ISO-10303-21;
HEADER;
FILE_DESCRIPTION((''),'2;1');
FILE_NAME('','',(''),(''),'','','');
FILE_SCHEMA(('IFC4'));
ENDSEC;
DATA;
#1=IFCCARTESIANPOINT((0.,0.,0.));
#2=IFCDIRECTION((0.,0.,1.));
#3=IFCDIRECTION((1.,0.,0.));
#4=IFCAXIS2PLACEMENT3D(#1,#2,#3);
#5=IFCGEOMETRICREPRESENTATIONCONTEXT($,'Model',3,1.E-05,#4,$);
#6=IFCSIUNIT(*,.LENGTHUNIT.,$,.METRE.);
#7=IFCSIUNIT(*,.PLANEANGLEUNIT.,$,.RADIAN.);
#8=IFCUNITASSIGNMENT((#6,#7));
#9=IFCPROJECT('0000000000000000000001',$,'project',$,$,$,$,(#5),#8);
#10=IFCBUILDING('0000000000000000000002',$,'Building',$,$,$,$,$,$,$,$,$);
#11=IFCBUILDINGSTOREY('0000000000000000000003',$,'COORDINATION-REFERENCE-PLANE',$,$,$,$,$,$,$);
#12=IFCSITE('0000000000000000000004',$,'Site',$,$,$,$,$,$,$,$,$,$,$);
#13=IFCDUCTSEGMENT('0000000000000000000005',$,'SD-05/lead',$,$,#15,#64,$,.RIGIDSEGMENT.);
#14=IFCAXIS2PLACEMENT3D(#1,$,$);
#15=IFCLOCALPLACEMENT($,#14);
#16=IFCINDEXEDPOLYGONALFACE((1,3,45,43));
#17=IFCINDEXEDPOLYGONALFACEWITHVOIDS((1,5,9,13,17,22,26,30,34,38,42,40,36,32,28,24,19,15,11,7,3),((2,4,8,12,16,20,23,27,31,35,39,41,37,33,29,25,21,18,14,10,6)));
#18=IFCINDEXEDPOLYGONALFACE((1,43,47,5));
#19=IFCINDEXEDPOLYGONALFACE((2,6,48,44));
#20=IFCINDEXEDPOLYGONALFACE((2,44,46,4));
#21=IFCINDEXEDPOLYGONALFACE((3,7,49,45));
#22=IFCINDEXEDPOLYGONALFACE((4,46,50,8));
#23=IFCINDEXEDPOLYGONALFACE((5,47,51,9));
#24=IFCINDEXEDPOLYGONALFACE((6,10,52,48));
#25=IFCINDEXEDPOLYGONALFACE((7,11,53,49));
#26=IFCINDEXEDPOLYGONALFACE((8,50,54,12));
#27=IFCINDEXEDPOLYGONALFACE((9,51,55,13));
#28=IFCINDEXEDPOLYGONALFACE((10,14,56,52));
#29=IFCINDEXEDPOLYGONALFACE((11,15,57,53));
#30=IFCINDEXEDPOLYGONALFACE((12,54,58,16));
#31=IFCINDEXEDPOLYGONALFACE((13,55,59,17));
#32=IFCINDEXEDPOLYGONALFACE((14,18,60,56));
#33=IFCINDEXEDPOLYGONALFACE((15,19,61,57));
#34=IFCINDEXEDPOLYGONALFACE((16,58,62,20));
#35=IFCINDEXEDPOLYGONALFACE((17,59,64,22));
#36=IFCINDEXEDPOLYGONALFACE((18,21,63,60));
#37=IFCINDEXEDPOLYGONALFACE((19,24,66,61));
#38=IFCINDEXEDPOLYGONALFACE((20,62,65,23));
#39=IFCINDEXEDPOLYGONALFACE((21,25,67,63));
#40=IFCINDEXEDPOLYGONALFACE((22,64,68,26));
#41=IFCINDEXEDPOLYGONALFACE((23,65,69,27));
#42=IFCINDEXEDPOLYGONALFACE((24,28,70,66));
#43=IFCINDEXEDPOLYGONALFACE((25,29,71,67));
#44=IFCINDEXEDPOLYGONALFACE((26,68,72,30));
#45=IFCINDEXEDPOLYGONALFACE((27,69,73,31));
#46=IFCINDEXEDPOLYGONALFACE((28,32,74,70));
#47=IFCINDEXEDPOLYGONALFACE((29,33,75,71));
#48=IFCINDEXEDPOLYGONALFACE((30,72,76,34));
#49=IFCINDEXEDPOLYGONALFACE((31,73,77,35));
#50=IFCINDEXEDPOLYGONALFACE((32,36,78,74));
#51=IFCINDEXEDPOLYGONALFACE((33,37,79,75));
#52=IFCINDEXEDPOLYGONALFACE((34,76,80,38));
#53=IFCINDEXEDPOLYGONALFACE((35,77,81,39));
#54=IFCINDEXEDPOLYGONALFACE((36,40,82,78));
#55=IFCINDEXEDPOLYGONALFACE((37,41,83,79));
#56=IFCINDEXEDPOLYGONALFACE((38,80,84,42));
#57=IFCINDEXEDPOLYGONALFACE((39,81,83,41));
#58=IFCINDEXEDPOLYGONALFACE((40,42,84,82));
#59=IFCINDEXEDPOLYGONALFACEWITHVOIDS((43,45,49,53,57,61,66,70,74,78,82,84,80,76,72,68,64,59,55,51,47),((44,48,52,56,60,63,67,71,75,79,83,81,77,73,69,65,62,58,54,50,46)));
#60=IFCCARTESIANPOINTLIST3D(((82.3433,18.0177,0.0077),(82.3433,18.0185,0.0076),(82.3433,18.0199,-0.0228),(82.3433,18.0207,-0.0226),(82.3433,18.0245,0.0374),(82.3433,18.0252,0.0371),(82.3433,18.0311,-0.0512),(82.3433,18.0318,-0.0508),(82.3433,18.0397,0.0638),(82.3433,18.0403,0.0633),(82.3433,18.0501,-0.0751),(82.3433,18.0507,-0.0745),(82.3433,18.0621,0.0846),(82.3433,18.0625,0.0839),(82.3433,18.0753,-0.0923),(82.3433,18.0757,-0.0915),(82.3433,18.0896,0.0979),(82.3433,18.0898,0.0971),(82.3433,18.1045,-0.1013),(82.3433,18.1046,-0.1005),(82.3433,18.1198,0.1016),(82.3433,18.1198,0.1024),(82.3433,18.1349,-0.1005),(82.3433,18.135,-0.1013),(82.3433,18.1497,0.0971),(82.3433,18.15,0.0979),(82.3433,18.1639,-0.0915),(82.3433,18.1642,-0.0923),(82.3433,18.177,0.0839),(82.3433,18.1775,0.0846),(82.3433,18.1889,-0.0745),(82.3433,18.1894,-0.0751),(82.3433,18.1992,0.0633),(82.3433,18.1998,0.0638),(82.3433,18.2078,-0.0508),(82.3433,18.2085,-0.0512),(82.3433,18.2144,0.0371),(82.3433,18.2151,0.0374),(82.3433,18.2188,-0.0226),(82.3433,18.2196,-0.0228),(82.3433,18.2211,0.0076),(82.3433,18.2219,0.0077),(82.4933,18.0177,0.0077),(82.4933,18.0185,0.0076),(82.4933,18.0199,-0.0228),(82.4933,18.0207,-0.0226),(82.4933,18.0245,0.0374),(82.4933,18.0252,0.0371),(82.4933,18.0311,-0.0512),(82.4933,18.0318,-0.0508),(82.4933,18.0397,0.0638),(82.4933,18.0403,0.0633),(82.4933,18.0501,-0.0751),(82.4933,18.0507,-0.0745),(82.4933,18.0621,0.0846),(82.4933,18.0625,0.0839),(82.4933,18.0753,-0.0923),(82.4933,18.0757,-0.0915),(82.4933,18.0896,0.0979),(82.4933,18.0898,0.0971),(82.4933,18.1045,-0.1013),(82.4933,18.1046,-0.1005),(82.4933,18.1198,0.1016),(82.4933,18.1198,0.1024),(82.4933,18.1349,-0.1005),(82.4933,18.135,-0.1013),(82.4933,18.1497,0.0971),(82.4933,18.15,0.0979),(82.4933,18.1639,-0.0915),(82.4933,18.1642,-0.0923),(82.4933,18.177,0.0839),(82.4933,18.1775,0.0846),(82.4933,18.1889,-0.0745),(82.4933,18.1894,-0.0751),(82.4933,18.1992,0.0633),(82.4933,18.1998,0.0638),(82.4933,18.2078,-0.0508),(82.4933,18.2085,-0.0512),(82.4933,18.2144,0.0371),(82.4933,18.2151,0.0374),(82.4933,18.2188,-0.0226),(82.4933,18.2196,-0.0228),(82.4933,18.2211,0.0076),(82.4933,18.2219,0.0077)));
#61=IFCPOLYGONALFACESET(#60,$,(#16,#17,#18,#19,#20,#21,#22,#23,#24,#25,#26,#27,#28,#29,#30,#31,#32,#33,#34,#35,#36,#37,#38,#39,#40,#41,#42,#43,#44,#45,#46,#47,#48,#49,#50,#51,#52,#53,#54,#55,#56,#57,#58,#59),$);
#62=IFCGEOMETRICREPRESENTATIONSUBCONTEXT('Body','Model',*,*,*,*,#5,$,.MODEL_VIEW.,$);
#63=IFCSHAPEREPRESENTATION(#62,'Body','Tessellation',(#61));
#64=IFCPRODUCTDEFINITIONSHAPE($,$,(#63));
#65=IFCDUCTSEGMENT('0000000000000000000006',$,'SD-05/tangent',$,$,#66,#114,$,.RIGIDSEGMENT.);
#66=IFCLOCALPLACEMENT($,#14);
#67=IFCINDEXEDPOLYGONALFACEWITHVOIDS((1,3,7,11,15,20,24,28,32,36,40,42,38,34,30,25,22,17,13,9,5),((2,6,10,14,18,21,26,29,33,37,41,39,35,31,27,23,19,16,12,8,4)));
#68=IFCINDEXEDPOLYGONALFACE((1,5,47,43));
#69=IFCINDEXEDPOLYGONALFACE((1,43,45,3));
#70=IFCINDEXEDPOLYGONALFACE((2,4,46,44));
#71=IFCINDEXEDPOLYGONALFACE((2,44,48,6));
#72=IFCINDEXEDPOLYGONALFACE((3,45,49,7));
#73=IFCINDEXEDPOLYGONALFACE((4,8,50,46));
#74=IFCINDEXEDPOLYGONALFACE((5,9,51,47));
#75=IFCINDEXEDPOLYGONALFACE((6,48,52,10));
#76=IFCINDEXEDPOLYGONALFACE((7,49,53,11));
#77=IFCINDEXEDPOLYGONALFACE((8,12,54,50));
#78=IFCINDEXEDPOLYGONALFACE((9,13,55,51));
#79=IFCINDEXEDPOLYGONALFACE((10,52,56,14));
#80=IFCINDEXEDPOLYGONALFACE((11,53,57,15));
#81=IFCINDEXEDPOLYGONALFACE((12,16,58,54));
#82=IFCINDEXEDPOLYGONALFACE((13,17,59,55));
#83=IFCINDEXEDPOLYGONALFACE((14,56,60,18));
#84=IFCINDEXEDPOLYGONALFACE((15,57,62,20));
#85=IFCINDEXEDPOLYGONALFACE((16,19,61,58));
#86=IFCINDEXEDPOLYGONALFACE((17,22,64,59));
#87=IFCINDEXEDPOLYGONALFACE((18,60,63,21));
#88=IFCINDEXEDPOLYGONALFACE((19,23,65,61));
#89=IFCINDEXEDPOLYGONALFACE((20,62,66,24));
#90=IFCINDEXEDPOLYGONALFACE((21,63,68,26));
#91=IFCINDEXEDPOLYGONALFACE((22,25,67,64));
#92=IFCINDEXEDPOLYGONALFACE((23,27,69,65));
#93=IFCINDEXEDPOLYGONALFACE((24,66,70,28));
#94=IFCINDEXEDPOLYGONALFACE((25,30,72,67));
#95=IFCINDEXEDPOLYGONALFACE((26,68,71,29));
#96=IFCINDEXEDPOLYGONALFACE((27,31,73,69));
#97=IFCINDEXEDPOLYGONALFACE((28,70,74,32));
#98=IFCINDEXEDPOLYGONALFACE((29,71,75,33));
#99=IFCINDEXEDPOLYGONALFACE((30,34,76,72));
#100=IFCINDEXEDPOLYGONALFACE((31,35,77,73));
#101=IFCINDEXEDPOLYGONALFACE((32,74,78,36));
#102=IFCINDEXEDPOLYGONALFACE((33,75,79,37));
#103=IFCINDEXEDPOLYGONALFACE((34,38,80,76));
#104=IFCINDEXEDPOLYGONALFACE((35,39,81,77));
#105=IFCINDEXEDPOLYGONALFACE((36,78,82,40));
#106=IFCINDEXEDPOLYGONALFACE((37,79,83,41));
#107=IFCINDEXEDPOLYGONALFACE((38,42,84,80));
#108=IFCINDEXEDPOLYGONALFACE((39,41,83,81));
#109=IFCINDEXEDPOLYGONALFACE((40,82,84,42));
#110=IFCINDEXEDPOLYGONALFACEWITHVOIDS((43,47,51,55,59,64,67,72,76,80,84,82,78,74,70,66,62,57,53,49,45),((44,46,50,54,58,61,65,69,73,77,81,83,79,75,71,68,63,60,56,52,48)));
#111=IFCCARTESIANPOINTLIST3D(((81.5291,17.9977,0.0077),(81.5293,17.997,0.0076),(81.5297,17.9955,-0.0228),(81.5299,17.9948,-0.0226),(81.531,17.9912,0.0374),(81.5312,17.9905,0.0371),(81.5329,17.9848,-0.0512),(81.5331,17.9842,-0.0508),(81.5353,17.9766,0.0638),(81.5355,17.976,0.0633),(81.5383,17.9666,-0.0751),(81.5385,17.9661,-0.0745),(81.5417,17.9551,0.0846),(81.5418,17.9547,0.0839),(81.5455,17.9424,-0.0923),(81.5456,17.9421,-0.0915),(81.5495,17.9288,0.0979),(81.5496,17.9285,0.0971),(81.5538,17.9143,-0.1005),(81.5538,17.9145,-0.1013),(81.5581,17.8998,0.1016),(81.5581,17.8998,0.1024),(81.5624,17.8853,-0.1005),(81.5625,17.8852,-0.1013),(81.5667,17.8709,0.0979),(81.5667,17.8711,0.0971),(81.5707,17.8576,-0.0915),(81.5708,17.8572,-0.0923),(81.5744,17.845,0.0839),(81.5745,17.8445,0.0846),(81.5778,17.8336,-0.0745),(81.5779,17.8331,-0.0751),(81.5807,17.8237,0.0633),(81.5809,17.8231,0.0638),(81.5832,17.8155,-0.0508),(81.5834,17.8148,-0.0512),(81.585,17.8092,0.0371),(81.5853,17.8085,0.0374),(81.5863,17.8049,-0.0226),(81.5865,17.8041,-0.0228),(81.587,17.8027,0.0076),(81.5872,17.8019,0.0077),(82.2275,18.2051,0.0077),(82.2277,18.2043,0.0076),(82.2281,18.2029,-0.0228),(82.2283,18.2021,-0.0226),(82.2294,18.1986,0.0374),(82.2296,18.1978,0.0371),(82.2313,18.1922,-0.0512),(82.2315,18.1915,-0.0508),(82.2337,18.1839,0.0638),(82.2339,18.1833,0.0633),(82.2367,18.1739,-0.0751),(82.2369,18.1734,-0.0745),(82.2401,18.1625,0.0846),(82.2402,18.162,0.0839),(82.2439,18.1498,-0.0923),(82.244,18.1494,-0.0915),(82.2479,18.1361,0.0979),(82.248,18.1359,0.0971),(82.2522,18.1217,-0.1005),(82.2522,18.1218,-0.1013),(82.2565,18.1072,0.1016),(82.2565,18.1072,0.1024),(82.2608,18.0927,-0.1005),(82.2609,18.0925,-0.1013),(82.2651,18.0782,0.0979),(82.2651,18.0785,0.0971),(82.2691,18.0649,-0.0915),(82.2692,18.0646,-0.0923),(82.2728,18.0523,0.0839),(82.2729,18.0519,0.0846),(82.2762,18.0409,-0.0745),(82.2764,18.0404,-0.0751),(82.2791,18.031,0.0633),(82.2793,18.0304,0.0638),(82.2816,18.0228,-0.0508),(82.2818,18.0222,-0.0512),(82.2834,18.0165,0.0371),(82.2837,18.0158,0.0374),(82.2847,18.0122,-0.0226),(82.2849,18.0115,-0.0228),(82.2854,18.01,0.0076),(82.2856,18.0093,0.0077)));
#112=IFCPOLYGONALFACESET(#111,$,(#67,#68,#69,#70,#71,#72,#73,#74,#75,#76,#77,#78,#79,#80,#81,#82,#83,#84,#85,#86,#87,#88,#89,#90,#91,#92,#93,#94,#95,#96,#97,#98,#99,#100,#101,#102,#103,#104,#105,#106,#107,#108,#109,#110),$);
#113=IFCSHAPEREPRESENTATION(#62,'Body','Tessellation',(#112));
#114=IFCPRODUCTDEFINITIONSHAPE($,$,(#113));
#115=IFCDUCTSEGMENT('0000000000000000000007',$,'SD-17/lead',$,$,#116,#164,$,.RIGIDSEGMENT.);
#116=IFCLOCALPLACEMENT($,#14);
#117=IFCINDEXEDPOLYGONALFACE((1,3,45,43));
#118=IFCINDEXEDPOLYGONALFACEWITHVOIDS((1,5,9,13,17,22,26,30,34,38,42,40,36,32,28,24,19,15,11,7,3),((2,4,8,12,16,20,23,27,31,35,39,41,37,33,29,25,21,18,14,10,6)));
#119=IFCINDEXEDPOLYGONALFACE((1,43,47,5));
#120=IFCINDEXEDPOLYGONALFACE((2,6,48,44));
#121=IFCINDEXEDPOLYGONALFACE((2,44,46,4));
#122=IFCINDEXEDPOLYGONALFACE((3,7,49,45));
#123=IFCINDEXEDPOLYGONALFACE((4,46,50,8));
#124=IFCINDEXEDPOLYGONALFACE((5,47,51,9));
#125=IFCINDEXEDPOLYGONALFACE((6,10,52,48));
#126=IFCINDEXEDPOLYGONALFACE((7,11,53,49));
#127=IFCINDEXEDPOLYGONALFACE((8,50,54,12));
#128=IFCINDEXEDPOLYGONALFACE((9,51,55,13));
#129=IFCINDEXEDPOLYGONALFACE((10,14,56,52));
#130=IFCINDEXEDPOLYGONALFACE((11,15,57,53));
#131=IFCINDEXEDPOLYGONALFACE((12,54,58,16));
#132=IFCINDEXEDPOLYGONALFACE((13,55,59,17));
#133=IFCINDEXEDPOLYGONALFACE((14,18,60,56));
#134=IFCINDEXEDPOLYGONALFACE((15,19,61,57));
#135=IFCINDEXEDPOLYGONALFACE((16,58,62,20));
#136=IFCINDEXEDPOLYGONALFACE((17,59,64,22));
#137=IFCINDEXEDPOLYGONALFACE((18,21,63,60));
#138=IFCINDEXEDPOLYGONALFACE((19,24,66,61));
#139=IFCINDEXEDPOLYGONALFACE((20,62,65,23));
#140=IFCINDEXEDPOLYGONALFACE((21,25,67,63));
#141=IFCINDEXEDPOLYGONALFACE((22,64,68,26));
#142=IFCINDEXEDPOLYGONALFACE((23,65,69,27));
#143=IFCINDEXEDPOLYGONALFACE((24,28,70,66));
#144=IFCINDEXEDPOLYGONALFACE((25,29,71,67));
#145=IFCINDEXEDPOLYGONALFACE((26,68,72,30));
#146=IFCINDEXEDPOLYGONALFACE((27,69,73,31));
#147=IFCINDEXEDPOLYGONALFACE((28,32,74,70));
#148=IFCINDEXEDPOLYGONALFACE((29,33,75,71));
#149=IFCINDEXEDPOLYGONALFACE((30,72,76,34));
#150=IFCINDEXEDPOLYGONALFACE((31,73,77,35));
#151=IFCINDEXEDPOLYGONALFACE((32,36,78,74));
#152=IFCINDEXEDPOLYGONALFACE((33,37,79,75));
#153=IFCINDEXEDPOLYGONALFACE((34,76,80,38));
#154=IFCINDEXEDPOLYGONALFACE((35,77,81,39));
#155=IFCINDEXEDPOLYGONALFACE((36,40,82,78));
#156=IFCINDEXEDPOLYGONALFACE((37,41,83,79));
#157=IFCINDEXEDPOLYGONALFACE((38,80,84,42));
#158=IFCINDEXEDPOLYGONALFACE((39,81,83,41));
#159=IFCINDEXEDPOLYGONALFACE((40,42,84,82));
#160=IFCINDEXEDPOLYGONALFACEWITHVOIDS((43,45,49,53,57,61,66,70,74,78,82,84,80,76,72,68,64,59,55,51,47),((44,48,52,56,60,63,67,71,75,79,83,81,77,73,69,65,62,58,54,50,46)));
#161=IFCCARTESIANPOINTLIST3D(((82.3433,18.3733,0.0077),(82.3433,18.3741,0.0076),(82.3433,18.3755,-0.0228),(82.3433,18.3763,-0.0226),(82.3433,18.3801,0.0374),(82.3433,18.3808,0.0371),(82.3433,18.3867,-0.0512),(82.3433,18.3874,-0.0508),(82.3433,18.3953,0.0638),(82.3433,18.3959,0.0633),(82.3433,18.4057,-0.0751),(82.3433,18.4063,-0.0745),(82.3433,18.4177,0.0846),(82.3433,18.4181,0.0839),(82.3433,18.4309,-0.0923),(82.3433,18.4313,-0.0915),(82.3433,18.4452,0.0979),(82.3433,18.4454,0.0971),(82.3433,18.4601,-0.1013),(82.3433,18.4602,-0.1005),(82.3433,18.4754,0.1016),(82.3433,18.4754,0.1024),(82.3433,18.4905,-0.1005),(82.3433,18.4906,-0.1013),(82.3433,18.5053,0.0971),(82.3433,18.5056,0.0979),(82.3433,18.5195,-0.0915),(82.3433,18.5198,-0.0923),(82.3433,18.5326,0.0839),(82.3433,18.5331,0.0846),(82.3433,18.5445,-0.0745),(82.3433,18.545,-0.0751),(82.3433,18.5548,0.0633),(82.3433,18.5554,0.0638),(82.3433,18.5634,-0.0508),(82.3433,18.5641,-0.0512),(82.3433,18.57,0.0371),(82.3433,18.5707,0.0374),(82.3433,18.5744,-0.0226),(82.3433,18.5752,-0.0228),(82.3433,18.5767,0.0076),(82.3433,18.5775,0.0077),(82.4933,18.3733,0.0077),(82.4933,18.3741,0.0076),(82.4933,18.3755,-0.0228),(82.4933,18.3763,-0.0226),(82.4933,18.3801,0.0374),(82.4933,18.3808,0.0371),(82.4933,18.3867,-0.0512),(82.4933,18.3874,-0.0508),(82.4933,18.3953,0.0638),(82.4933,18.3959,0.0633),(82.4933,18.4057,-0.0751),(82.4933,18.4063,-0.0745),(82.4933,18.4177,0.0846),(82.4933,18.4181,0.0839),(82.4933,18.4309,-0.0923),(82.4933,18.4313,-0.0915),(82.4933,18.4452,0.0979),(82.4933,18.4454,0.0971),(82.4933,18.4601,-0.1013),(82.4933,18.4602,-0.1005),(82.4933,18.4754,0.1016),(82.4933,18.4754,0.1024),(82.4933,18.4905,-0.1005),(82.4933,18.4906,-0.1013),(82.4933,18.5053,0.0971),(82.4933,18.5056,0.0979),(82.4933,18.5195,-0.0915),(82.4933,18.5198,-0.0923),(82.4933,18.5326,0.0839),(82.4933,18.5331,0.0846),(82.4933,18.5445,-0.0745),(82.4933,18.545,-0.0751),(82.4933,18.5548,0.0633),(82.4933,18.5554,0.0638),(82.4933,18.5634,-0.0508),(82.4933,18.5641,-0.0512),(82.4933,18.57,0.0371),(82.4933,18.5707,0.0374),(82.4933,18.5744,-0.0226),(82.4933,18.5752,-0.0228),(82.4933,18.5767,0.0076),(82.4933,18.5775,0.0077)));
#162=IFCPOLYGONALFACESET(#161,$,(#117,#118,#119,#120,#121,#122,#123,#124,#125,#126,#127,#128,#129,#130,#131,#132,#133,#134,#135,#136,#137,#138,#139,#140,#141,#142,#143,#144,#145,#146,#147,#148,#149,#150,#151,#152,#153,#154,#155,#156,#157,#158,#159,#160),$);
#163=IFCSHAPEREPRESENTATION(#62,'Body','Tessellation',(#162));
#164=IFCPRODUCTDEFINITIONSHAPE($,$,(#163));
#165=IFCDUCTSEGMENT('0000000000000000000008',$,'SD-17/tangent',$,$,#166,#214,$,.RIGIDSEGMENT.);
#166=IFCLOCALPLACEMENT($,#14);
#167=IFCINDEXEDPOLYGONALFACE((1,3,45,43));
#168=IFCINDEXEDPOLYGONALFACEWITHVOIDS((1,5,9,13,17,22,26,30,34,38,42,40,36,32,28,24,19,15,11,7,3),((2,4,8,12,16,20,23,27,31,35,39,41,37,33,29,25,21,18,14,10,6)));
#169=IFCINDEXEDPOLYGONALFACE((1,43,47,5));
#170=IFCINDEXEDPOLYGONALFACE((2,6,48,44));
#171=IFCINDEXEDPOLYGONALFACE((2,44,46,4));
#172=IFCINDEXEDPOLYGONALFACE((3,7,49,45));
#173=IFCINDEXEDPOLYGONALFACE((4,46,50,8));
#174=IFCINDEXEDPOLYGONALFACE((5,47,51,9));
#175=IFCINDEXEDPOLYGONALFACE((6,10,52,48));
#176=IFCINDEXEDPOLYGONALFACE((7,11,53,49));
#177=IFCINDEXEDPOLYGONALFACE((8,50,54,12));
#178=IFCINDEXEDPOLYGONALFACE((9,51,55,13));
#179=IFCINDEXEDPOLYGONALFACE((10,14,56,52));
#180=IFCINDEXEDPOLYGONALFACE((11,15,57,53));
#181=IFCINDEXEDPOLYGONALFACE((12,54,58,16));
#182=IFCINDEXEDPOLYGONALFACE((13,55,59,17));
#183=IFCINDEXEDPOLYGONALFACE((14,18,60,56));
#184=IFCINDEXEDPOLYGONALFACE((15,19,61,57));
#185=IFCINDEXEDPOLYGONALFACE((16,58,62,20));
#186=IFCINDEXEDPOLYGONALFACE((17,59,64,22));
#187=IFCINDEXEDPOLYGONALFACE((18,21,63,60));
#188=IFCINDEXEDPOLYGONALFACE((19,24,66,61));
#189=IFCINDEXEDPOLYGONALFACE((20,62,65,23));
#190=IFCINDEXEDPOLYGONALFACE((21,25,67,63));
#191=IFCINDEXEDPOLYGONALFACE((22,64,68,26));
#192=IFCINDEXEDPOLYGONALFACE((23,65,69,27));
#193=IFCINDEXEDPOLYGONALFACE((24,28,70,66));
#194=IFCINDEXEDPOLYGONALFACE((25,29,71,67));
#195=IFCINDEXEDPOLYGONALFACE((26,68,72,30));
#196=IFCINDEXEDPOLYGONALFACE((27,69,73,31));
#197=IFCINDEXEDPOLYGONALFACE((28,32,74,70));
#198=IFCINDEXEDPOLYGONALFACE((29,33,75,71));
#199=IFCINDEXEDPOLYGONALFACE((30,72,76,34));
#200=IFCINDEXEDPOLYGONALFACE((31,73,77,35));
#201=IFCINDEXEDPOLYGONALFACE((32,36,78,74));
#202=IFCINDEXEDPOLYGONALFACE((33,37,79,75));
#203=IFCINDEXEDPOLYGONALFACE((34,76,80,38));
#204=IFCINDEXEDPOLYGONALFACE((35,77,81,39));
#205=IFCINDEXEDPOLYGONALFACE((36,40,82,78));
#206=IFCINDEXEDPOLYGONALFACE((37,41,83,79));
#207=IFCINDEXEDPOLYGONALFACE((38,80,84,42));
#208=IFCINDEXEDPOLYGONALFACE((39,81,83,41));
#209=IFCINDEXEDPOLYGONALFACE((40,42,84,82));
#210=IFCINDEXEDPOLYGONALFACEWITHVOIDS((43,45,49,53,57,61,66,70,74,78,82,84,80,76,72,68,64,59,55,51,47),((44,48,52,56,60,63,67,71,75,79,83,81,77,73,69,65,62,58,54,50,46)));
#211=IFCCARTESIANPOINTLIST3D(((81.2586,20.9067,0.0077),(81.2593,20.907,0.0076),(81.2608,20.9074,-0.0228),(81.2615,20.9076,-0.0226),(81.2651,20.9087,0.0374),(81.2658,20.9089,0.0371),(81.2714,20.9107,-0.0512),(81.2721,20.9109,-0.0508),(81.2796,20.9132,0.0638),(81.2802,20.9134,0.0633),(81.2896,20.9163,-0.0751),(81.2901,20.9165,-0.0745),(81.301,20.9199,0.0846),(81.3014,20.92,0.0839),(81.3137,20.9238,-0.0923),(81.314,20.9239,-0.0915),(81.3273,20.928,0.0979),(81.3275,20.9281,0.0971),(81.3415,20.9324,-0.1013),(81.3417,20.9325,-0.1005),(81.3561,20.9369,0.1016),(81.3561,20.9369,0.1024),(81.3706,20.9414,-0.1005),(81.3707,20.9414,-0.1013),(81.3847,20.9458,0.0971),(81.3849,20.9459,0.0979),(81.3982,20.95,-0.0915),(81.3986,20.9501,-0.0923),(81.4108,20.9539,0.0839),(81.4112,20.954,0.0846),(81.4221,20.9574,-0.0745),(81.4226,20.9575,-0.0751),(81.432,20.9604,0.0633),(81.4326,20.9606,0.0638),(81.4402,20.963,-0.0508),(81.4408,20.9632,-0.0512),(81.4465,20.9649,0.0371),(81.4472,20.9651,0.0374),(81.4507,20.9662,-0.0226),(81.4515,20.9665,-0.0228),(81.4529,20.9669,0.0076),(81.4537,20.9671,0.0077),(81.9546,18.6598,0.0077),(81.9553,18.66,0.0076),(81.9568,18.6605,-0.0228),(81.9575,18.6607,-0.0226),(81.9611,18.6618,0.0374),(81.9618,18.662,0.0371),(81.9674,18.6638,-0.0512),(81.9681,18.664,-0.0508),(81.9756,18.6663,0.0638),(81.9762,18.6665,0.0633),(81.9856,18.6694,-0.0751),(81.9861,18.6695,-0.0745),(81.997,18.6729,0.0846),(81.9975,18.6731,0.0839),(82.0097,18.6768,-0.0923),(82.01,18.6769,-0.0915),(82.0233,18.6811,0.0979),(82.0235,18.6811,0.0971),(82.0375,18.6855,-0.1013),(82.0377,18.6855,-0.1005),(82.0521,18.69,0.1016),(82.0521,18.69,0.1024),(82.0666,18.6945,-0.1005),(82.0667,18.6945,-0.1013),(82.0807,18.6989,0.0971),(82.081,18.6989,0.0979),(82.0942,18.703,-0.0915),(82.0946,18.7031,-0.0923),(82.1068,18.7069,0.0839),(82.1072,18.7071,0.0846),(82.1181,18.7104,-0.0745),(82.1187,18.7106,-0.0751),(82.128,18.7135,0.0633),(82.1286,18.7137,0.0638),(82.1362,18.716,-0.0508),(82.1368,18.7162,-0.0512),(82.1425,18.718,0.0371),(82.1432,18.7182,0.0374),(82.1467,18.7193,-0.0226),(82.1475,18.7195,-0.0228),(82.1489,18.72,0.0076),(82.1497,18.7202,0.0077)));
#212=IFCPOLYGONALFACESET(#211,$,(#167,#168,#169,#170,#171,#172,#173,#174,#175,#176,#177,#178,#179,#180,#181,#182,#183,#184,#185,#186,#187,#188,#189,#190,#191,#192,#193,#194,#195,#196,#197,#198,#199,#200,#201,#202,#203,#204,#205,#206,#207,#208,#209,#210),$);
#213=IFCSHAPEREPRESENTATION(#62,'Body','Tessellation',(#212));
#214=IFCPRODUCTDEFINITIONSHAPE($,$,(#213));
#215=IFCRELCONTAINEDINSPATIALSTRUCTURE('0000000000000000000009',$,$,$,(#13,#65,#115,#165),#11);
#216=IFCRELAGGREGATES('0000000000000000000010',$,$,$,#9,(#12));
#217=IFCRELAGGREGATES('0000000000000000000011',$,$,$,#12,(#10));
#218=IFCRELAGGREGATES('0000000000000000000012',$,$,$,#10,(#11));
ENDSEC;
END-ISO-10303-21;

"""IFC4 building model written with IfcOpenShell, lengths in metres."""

from ifc_helpers import new_model, si_unit, frame, origin_with_axes, place, context, subcontext, project, spatial, hollow_circle, extrude, element, save


model = new_model("IFC4")

# Units and contexts
model_context = context("Model", 3, precision=1e-05, world=origin_with_axes())
body_context_1 = subcontext(model_context, "Body", "Model", "MODEL_VIEW")
ifc_project = project(units=[si_unit("LENGTHUNIT", "METRE"), si_unit("PLANEANGLEUNIT", "RADIAN")], contexts=[model_context])

# Site, building, storey
site = spatial("IfcSite", under=ifc_project, Name="Site")
building = spatial("IfcBuilding", under=site, Name="Building")
storey = spatial("IfcBuildingStorey", under=building, Name="COORDINATION-REFERENCE-PLANE")

# Duct segment
duct_segment_1_placement = place(None, frame((82.4933, 18.1198, 0.0), z_axis=(-1.0, 0.0, 0.0), x_axis=(0.0, 0.0, 1.0)))
element("IfcDuctSegment", 1, at=duct_segment_1_placement, inside=storey, Name="SD-05/lead", PredefinedType="RIGIDSEGMENT", context=body_context_1, shape_type="SweptSolid", body=[
    extrude(hollow_circle(Radius=0.1024, WallThickness=0.0008), origin_with_axes(), (0.0, 0.0, 1.0), 0.15),
])

# Duct segment
duct_segment_2_placement = place(None, frame((82.2565, 18.1072, 0.0), z_axis=(-0.958645, -0.284603, 0.0), x_axis=(0.0, 0.0, 1.0)))
element("IfcDuctSegment", 2, at=duct_segment_2_placement, inside=storey, Name="SD-05/tangent", PredefinedType="RIGIDSEGMENT", context=body_context_1, shape_type="SweptSolid", body=[
    extrude(hollow_circle(Radius=0.1024, WallThickness=0.0008), origin_with_axes(), (0.0, 0.0, 1.0), 0.7285),
])

# Duct segment
duct_segment_3_placement = place(None, frame((82.4933, 18.4754, 0.0), z_axis=(-1.0, 0.0, 0.0), x_axis=(0.0, 0.0, 1.0)))
element("IfcDuctSegment", 3, at=duct_segment_3_placement, inside=storey, Name="SD-17/lead", PredefinedType="RIGIDSEGMENT", context=body_context_1, shape_type="SweptSolid", body=[
    extrude(hollow_circle(Radius=0.1024, WallThickness=0.0008), origin_with_axes(), (0.0, 0.0, 1.0), 0.15),
])

# Duct segment
duct_segment_4_placement = place(None, frame((82.0521, 18.69, 0.0), z_axis=(-0.295887, 0.955223, 0.0), x_axis=(0.0, 0.0, 1.0)))
element("IfcDuctSegment", 4, at=duct_segment_4_placement, inside=storey, Name="SD-17/tangent", PredefinedType="RIGIDSEGMENT", context=body_context_1, shape_type="SweptSolid", body=[
    extrude(hollow_circle(Radius=0.1024, WallThickness=0.0008), origin_with_axes(), (0.0, 0.0, 1.0), 2.3523),
])

save(model, "model.ifc")
